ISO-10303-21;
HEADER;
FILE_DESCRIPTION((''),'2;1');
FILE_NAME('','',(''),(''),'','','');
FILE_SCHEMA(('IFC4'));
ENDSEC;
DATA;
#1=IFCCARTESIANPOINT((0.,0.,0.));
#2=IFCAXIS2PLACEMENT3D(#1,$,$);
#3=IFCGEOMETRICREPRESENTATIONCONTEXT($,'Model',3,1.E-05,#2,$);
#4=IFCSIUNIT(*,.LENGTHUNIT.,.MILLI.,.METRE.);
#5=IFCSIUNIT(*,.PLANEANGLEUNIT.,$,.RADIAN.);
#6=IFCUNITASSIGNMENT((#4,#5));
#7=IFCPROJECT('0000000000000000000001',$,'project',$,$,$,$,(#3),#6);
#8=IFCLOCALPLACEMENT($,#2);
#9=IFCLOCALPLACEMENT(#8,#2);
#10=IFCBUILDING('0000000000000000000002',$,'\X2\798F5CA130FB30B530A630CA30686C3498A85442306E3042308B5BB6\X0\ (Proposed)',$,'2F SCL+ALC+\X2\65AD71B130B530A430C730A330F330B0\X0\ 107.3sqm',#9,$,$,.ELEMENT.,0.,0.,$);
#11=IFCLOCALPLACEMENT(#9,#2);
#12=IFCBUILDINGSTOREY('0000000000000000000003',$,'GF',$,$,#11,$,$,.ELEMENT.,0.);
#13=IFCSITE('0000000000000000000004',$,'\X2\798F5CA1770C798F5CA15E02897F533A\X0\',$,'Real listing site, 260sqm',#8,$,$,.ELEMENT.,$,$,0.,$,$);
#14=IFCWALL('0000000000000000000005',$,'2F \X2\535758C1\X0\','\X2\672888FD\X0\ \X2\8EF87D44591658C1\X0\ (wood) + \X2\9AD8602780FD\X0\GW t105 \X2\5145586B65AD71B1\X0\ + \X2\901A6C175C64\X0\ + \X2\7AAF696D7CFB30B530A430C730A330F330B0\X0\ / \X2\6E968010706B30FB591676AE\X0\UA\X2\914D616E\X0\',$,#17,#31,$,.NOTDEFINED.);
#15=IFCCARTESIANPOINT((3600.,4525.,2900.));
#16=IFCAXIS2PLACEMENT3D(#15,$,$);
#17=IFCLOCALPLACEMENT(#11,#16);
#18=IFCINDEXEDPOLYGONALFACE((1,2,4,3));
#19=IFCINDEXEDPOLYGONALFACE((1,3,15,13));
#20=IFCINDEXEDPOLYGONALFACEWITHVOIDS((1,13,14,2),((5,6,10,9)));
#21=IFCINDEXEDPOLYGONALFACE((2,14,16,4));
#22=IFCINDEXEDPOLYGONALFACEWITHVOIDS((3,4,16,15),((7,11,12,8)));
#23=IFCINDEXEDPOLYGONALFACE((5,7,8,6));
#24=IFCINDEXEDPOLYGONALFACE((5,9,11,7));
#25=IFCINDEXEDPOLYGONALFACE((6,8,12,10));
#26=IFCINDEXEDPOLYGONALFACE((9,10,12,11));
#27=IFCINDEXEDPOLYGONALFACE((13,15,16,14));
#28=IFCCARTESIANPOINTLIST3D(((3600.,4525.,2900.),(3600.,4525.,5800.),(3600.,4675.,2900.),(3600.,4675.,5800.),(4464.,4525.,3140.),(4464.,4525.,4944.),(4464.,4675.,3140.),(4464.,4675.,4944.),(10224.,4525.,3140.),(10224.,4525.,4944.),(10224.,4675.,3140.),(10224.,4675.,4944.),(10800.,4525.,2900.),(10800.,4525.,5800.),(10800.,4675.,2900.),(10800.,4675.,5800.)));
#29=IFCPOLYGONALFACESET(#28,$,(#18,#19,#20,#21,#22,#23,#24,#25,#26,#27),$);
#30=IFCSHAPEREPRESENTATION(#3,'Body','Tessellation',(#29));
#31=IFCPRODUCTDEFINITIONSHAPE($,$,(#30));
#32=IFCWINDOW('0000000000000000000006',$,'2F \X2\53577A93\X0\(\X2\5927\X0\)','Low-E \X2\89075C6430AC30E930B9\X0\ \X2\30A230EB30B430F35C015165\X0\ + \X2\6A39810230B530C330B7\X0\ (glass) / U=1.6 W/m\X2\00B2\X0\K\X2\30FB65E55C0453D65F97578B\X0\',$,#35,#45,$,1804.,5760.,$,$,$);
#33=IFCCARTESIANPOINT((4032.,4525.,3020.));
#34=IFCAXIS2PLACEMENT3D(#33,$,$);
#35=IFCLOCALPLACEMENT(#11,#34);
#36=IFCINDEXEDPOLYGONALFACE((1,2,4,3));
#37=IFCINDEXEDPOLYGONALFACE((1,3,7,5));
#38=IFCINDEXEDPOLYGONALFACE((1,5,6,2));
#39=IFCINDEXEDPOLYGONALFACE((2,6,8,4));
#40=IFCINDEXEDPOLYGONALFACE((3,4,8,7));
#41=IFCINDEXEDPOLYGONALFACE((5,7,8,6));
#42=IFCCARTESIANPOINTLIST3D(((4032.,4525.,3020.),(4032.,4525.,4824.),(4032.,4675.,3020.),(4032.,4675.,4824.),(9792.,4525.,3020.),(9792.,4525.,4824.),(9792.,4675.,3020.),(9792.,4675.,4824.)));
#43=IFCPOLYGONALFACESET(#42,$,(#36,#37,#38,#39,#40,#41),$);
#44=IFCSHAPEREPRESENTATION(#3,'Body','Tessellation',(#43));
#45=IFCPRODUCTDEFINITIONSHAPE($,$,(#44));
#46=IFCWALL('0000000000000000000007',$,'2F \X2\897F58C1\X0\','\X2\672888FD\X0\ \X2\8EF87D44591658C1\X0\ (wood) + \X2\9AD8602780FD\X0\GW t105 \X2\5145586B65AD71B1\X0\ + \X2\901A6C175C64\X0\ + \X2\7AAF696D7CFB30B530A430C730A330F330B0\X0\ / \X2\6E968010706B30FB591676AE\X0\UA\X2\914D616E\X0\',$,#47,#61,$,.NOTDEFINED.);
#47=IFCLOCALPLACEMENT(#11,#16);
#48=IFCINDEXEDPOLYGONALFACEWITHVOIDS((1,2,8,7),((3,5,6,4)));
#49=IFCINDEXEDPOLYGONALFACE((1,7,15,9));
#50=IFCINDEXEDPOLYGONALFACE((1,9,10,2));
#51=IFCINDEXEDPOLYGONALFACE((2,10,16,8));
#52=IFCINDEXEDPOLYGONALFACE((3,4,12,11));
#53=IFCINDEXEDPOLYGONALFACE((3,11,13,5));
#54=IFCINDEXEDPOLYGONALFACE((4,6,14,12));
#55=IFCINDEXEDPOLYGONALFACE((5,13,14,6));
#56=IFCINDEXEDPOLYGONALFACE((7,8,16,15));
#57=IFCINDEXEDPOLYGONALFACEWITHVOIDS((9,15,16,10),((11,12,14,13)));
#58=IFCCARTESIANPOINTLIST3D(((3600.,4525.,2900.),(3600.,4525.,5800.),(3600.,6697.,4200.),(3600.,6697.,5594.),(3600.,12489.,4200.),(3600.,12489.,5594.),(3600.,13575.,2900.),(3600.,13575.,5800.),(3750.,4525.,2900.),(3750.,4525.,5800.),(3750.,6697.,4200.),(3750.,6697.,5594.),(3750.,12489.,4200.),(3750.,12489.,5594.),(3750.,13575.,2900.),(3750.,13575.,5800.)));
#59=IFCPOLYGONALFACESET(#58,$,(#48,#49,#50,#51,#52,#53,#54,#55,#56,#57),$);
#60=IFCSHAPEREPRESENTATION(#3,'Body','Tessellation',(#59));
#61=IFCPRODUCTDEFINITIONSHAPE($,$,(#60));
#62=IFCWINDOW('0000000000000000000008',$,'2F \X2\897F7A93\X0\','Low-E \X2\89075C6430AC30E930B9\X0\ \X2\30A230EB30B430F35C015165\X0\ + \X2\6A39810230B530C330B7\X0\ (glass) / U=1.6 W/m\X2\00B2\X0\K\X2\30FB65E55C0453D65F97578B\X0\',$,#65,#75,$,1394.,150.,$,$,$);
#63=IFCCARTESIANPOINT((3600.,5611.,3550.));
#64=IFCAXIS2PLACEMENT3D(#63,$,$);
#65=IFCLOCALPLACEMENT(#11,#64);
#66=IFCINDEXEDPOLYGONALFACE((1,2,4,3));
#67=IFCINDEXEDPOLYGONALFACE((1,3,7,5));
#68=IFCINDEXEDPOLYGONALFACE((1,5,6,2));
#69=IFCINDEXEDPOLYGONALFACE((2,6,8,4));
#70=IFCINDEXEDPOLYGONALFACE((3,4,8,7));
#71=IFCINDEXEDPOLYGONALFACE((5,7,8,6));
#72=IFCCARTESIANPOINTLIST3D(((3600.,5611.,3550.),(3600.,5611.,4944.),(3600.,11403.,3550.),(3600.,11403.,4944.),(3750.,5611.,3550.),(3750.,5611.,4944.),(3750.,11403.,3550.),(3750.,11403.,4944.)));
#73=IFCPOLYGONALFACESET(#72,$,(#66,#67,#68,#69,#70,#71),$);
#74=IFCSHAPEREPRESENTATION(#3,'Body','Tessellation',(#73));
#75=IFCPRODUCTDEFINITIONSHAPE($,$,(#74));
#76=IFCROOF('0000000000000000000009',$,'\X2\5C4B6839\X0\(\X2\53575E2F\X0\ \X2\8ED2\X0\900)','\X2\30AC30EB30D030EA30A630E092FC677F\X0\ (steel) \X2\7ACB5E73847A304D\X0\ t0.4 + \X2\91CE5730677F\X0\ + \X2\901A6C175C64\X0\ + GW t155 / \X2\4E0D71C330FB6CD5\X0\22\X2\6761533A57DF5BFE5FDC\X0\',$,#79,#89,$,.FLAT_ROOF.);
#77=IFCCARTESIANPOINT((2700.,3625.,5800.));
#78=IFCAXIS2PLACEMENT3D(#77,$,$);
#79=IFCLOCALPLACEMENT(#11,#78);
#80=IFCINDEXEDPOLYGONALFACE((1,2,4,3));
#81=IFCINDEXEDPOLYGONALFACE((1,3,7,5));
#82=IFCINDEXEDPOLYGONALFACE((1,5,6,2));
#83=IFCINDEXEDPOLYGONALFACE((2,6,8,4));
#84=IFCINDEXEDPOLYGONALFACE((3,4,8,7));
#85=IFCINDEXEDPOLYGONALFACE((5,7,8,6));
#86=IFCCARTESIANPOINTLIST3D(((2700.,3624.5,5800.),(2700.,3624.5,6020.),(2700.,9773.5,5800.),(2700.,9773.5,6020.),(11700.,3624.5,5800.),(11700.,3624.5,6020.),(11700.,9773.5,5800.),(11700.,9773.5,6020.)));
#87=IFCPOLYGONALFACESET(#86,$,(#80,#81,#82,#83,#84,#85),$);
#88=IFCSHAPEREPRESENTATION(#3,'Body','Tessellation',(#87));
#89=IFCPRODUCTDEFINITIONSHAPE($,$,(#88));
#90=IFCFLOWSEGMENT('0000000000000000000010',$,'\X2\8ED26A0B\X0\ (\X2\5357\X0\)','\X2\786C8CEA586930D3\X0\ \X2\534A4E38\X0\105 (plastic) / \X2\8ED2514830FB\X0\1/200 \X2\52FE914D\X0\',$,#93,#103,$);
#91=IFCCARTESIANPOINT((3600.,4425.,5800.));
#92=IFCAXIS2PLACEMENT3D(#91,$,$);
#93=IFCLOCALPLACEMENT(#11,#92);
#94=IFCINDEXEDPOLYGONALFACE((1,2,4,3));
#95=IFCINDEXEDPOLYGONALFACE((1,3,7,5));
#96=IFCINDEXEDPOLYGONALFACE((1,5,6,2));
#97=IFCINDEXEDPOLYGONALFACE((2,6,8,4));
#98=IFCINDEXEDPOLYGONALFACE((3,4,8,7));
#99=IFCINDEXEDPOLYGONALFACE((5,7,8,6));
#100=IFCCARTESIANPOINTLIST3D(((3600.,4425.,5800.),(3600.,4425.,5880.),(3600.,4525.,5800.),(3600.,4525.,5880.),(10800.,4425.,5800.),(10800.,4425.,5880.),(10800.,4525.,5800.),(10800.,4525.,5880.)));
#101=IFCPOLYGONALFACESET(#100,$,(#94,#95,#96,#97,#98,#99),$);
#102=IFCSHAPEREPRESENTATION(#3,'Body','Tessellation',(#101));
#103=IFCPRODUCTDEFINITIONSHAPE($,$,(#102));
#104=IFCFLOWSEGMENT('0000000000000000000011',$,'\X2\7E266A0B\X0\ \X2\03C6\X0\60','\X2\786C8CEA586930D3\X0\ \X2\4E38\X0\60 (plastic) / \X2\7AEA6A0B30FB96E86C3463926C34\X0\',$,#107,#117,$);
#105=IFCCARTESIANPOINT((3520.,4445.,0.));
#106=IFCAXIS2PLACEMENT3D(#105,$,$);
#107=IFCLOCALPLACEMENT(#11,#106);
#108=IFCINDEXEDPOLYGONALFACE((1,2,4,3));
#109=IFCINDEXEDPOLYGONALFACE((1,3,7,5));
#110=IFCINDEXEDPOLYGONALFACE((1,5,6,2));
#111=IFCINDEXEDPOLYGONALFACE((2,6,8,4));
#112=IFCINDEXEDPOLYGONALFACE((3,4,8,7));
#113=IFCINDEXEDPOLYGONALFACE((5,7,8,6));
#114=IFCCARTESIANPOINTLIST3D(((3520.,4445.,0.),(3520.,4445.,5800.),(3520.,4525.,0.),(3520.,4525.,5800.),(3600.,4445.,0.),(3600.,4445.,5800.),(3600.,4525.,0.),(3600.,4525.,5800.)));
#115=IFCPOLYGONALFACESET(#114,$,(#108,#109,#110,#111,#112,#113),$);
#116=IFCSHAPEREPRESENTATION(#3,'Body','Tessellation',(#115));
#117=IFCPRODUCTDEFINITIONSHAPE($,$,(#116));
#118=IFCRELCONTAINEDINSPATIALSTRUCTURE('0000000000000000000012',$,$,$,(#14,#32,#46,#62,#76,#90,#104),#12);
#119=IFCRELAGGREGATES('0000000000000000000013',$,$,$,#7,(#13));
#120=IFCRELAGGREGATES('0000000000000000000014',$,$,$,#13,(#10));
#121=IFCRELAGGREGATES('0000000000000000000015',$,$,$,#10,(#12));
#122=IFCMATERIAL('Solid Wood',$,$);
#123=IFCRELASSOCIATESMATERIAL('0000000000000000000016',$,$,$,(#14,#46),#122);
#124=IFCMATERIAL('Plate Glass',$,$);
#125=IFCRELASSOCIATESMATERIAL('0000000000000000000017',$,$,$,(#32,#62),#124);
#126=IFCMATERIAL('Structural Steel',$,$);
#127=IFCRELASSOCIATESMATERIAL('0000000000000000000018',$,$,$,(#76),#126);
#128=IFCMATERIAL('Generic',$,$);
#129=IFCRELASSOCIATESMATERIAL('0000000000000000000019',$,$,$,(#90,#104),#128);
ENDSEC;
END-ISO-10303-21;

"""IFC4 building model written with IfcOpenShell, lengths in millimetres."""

from ifc_helpers import new_model, si_unit, frame, frame_2d, origin, place, context, project, spatial, rectangle, extrude, material, element, fill, save


model = new_model("IFC4")

# Units and contexts
model_context = context("Model", 3, precision=1e-05, world=origin())
ifc_project = project(units=[si_unit("LENGTHUNIT", "METRE", prefix="MILLI"), si_unit("PLANEANGLEUNIT", "RADIAN")], contexts=[model_context])

# Site, building, storey
site_placement = place(None, origin())
site = spatial("IfcSite", under=ifc_project, at=site_placement, Name="福岡県福岡市西区", ObjectType="Real listing site, 260sqm", CompositionType="ELEMENT", RefElevation=0.0)
building_placement = place(site_placement, origin())
building = spatial("IfcBuilding", under=site, at=building_placement, Name="福岡・サウナと水風呂のある家 (Proposed)", ObjectType="2F SCL+ALC+断熱サイディング 107.3sqm", CompositionType="ELEMENT", ElevationOfRefHeight=0.0, ElevationOfTerrain=0.0)
storey_placement = place(building_placement, origin())
storey = spatial("IfcBuildingStorey", under=building, at=storey_placement, Name="GF", CompositionType="ELEMENT", Elevation=0.0)

# Shared definitions
ifc_material_1 = material(Name="Solid Wood")

# Shared definitions
ifc_material_2 = material(Name="Plate Glass")

# Walls, openings, windows
wall_1_placement = place(storey_placement, frame((3600.0, 4525.0, 2900.0)))
wall_1 = element("IfcWall", 1, at=wall_1_placement, inside=storey, material=ifc_material_1, Name="2F 南壁", Description="木製 軸組外壁 (wood) + 高性能GW t105 充填断熱 + 通気層 + 窯業系サイディング / 準耐火・外皮UA配慮", PredefinedType="NOTDEFINED", context=model_context, shape_type="SweptSolid", body=[
    extrude(rectangle(XDim=7200.0, YDim=150.0, at=frame_2d((3600.0, 75.0))), frame((3600.0, 4525.0, 2900.0)), (0.0, 0.0, 1.0), 2900.0),
])
opening_1_placement = place(storey_placement, frame((4032.0, 4525.0, 3020.0)))
opening_1 = element("IfcOpeningElement", 2, at=opening_1_placement, cuts=wall_1, PredefinedType="NOTDEFINED", context=model_context, shape_type="SweptSolid", body=[
    extrude(rectangle(XDim=5760.0, YDim=150.0, at=frame_2d((2880.0, 75.0))), frame((4032.0, 4525.0, 3020.0)), (0.0, 0.0, 1.0), 1804.0),
])
window_1_placement = place(storey_placement, frame((4032.0, 4525.0, 3020.0)))
window_1 = element("IfcWindow", 3, at=window_1_placement, inside=storey, material=ifc_material_2, Name="2F 南窓(大)", Description="Low-E 複層ガラス アルゴン封入 + 樹脂サッシ (glass) / U=1.6 W/m²K・日射取得型", OverallHeight=1804.0, OverallWidth=5760.0, context=model_context, shape_type="SweptSolid", body=[
    extrude(rectangle(XDim=5760.0, YDim=150.0, at=frame_2d((2880.0, 75.0))), frame((4032.0, 4525.0, 3020.0)), (0.0, 0.0, 1.0), 1804.0),
])
fill(opening_1, window_1)
wall_2_placement = place(storey_placement, frame((3600.0, 4525.0, 2900.0)))
wall_2 = element("IfcWall", 4, at=wall_2_placement, inside=storey, material=ifc_material_1, Name="2F 西壁", Description="木製 軸組外壁 (wood) + 高性能GW t105 充填断熱 + 通気層 + 窯業系サイディング / 準耐火・外皮UA配慮", PredefinedType="NOTDEFINED", context=model_context, shape_type="SweptSolid", body=[
    extrude(rectangle(XDim=150.0, YDim=9050.0, at=frame_2d((75.0, 4525.0))), frame((3600.0, 4525.0, 2900.0)), (0.0, 0.0, 1.0), 2900.0),
])
opening_2_placement = place(storey_placement, frame((3600.0, 5611.0, 3550.0)))
opening_2 = element("IfcOpeningElement", 5, at=opening_2_placement, cuts=wall_2, PredefinedType="NOTDEFINED", context=model_context, shape_type="SweptSolid", body=[
    extrude(rectangle(XDim=150.0, YDim=5792.0, at=frame_2d((75.0, 2896.0))), frame((3600.0, 5611.0, 3550.0)), (0.0, 0.0, 1.0), 1394.0),
])
window_2_placement = place(storey_placement, frame((3600.0, 5611.0, 3550.0)))
window_2 = element("IfcWindow", 6, at=window_2_placement, inside=storey, material=ifc_material_2, Name="2F 西窓", Description="Low-E 複層ガラス アルゴン封入 + 樹脂サッシ (glass) / U=1.6 W/m²K・日射取得型", OverallHeight=1394.0, OverallWidth=150.0, context=model_context, shape_type="SweptSolid", body=[
    extrude(rectangle(XDim=150.0, YDim=5792.0, at=frame_2d((75.0, 2896.0))), frame((3600.0, 5611.0, 3550.0)), (0.0, 0.0, 1.0), 1394.0),
])
fill(opening_2, window_2)

# Roof
ifc_material_3 = material(Name="Structural Steel")
for number, where, name in (
    (7, (2700.0, 3625.0, 5800.0), "屋根(南帯 軒900)"),
):
    element("IfcRoof", number, at=place(storey_placement, frame(where)), inside=storey, material=ifc_material_3, Name=name, Description="ガルバリウム鋼板 (steel) 立平葺き t0.4 + 野地板 + 通気層 + GW t155 / 不燃・法22条区域対応", PredefinedType="FLAT_ROOF", context=model_context, shape_type="SweptSolid", body=[
        extrude(rectangle(XDim=9000.0, YDim=6149.0, at=frame_2d((4500.0, 3074.0))), frame((2700.0, 3625.0, 5800.0)), (0.0, 0.0, 1.0), 220.0),
    ])

# Flow segments
ifc_material_4 = material(Name="Generic")
flow_segment_1_placement = place(storey_placement, frame((3600.0, 4425.0, 5800.0)))
element("IfcFlowSegment", 8, at=flow_segment_1_placement, inside=storey, material=ifc_material_4, Name="軒樋 (南)", Description="硬質塩ビ 半丸105 (plastic) / 軒先・1/200 勾配", context=model_context, shape_type="SweptSolid", body=[
    extrude(rectangle(XDim=7200.0, YDim=100.0, at=frame_2d((3600.0, 50.0))), frame((3600.0, 4425.0, 5800.0)), (0.0, 0.0, 1.0), 80.0),
])
flow_segment_2_placement = place(storey_placement, frame((3520.0, 4445.0, 0.0)))
element("IfcFlowSegment", 9, at=flow_segment_2_placement, inside=storey, material=ifc_material_4, Name="縦樋 φ60", Description="硬質塩ビ 丸60 (plastic) / 竪樋・雨水排水", context=model_context, shape_type="SweptSolid", body=[
    extrude(rectangle(XDim=80.0, YDim=80.0, at=frame_2d((40.0, 40.0))), frame((3520.0, 4445.0, 0.0)), (0.0, 0.0, 1.0), 5800.0),
])

save(model, "model.ifc")
